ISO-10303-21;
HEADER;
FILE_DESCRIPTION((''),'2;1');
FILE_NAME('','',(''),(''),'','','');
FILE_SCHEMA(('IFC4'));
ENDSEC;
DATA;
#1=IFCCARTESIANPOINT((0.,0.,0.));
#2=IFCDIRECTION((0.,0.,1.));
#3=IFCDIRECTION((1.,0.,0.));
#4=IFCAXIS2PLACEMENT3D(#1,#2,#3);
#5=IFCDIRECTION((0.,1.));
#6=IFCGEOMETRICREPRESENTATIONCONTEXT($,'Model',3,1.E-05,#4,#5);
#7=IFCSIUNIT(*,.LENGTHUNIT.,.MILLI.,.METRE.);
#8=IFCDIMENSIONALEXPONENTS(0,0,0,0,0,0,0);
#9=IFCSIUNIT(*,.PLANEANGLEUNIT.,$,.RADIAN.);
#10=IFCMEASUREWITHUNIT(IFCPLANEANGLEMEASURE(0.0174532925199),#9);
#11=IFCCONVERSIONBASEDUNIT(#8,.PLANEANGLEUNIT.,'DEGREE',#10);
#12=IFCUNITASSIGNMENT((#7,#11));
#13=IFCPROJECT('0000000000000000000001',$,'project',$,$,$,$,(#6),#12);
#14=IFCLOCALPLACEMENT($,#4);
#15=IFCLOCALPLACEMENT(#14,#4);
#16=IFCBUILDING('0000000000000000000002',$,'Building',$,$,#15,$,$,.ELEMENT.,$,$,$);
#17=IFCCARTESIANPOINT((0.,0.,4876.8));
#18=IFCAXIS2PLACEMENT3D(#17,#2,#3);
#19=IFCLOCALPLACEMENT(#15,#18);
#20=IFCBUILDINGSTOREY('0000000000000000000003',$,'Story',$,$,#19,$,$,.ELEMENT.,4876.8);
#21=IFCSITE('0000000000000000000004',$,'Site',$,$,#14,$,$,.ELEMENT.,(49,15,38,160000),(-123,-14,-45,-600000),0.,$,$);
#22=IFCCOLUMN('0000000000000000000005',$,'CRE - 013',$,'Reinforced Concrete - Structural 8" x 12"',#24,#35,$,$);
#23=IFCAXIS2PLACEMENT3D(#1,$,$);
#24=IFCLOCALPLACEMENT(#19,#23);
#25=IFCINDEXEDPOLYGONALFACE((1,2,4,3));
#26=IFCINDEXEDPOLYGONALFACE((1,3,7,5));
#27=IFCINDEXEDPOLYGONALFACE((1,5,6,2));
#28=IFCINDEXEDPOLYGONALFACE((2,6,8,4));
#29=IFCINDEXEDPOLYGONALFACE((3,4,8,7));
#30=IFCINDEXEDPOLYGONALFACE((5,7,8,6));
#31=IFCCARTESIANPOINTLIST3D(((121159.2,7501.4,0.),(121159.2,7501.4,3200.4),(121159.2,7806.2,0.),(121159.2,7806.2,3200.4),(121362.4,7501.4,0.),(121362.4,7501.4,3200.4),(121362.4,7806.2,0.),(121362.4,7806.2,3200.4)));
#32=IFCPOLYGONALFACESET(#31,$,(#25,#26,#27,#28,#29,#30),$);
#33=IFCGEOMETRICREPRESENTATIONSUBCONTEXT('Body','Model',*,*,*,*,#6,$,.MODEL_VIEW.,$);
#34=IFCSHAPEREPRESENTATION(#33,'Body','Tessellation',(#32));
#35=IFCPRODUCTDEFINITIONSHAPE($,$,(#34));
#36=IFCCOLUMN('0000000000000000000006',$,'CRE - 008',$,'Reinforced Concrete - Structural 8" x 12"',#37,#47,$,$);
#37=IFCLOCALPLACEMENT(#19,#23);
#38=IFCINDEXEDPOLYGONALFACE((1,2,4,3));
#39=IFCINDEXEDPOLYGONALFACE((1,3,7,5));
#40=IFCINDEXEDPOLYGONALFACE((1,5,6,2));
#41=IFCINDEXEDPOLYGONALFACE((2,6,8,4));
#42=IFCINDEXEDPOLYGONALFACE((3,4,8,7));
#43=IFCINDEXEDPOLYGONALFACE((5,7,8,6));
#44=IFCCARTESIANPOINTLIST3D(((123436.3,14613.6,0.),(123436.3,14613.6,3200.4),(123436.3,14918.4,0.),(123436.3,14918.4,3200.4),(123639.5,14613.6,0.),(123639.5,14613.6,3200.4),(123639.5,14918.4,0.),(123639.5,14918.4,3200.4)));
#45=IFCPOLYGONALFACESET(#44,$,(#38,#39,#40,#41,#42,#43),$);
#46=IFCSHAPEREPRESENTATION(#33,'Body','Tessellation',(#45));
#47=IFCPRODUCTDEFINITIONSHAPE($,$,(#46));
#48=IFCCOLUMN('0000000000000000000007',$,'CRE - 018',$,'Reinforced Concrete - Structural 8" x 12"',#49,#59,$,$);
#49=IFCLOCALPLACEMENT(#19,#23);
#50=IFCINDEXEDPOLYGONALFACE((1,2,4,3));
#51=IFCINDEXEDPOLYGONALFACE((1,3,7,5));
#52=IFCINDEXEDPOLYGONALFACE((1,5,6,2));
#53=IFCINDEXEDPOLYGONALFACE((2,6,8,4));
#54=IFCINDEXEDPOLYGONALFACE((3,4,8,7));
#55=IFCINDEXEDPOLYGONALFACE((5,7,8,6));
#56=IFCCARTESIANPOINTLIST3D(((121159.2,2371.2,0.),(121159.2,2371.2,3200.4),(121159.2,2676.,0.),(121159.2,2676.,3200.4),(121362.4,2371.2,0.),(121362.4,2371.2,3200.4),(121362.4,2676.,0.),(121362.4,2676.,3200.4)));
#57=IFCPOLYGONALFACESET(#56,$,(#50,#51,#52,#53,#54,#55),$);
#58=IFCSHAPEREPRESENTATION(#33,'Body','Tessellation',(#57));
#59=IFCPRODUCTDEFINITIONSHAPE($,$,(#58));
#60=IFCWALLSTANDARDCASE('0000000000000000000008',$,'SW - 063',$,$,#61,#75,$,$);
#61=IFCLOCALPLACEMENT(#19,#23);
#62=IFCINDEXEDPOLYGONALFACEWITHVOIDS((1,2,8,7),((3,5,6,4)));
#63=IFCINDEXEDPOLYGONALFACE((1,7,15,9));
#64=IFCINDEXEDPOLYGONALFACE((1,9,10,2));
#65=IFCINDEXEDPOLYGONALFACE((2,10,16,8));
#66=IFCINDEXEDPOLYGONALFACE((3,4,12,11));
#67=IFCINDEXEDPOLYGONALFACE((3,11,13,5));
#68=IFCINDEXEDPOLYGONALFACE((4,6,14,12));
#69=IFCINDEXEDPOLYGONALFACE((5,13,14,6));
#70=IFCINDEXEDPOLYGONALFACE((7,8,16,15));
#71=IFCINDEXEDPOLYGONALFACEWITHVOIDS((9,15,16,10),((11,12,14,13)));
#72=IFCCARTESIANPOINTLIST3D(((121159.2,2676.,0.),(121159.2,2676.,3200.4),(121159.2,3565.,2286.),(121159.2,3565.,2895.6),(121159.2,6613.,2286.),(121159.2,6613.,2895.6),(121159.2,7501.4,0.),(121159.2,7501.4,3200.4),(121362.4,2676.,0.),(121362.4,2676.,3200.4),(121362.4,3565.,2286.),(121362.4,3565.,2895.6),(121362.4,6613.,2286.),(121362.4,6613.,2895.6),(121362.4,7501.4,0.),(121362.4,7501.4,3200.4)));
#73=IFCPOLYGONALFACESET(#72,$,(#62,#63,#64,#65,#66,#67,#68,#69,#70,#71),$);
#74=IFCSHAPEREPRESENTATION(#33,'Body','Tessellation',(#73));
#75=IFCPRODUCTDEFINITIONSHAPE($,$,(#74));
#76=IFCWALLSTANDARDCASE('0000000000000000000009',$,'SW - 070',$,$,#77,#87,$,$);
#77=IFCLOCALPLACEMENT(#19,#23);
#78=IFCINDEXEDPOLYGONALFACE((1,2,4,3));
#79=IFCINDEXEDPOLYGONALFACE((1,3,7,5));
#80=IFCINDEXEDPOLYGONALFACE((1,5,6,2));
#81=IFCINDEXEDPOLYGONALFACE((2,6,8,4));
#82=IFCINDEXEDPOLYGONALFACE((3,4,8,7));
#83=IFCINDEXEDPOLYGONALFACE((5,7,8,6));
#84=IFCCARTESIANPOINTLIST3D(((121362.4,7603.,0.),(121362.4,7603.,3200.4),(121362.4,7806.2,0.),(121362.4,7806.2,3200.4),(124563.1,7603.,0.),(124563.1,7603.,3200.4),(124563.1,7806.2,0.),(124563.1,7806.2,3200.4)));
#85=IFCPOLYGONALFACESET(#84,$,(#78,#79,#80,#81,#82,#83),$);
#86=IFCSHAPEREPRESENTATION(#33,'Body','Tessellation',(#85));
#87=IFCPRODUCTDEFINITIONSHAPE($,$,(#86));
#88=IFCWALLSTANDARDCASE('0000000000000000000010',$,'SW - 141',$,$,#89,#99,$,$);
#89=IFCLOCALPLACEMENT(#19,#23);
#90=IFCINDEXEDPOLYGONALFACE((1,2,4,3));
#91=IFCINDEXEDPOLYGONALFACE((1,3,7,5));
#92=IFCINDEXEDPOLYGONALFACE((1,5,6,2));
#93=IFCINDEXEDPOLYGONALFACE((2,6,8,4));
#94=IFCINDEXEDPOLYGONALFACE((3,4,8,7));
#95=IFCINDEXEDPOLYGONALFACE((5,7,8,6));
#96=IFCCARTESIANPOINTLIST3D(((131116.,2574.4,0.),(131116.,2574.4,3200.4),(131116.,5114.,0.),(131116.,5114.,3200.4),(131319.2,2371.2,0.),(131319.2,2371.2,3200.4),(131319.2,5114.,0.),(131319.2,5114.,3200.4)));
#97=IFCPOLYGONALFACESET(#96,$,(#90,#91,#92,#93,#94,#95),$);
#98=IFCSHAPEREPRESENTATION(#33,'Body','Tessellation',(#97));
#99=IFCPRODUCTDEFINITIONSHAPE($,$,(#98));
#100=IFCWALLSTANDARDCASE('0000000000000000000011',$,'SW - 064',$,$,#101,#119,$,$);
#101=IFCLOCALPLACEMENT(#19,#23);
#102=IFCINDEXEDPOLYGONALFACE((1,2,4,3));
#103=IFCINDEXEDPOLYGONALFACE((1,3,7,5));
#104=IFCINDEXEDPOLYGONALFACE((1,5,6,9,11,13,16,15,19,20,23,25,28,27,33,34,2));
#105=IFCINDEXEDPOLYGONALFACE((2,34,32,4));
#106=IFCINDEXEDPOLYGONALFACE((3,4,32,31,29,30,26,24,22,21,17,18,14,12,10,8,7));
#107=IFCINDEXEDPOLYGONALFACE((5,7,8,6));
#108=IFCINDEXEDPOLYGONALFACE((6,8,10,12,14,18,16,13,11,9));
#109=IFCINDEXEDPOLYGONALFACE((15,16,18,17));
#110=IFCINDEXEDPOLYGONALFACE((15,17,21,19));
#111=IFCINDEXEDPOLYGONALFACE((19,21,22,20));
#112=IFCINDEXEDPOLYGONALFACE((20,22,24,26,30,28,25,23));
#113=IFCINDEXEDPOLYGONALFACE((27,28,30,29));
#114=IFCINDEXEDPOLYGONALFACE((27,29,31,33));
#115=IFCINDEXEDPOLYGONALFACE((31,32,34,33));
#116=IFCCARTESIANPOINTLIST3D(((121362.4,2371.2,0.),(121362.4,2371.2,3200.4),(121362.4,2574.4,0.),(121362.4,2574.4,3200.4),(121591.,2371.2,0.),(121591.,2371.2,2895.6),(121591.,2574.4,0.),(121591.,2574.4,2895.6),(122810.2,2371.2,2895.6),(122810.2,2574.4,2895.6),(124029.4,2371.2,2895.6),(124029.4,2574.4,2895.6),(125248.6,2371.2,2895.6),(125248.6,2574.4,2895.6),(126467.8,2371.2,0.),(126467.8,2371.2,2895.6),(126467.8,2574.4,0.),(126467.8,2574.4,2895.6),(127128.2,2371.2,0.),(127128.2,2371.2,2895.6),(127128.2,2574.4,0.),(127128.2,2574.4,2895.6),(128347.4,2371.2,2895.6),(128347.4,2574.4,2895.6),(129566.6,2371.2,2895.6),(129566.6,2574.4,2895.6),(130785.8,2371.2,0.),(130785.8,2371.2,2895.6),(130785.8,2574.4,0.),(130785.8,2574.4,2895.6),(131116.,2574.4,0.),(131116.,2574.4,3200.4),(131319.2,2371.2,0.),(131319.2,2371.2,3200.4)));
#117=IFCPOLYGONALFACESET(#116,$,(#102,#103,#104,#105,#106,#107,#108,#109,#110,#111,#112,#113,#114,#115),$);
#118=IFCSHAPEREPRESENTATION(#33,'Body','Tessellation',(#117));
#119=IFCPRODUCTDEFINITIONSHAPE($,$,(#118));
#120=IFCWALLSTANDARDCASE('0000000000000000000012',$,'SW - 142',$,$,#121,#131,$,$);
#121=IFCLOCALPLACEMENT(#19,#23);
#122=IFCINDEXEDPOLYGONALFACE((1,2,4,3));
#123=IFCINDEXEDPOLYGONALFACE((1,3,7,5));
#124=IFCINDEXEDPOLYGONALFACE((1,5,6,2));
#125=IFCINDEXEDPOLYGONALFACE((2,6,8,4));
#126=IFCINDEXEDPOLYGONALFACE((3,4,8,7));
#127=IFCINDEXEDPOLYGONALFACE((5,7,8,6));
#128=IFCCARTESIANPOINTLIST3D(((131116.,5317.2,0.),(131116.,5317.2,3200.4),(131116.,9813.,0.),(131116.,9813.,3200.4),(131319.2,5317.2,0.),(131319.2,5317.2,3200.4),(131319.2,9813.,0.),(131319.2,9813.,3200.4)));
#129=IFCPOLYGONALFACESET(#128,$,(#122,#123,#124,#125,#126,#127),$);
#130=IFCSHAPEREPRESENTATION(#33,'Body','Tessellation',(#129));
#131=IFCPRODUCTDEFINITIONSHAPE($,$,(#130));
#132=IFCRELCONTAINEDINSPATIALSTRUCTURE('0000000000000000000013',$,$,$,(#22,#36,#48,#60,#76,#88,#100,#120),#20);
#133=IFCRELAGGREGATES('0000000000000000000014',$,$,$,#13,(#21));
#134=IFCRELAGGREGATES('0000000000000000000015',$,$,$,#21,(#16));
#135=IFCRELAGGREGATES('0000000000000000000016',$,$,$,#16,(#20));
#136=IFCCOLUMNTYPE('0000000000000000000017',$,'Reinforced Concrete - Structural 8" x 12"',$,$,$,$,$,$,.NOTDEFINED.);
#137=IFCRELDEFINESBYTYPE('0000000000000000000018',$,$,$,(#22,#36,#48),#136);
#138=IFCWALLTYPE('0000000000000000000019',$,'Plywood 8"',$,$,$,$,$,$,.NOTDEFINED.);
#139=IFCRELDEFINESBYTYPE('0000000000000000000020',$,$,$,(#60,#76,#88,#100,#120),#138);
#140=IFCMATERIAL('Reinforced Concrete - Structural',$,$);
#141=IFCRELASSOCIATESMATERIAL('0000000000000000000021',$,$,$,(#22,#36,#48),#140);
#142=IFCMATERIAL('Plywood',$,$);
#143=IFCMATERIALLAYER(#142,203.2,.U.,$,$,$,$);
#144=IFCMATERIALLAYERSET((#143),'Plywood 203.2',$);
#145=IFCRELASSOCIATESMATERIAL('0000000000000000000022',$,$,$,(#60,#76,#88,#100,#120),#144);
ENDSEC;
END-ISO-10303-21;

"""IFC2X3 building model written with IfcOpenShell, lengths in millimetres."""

from ifc_helpers import new_model, entity, si_unit, converted_unit, direction, frame, origin_with_axes, origin_2d_with_axis, place, context, subcontext, project, spatial, polyline, rectangle, outline, extrude, material, layer, layer_set, layer_usage, type_object, element, save


model = new_model("IFC2X3")

# Units and contexts
model_context = context("Model", 3, precision=1e-05, world=origin_with_axes(), true_north=direction((0.0, 1.0)))
body_context = subcontext(model_context, "Body", "Model", "MODEL_VIEW")
ifc_project = project(units=[si_unit("LENGTHUNIT", "METRE", prefix="MILLI"), converted_unit("PLANEANGLEUNIT", "DEGREE", entity("IfcPlaneAngleMeasure", 0.0174532925199), si_unit("PLANEANGLEUNIT", "RADIAN"), dimensions=[0, 0, 0, 0, 0, 0, 0])], contexts=[model_context])

# Site, building, storey
site_placement = place(None, origin_with_axes())
site = spatial("IfcSite", under=ifc_project, at=site_placement, Name="Site", CompositionType="ELEMENT", RefLatitude=(49, 15, 38, 160000), RefLongitude=(-123, -14, -45, -600000), RefElevation=0.0)
building_placement = place(site_placement, origin_with_axes())
building = spatial("IfcBuilding", under=site, at=building_placement, Name="Building", CompositionType="ELEMENT")
storey_placement = place(building_placement, frame((0.0, 0.0, 4876.8), z_axis=(0.0, 0.0, 1.0), x_axis=(1.0, 0.0, 0.0)))
storey = spatial("IfcBuildingStorey", under=building, at=storey_placement, Name="Story", CompositionType="ELEMENT", Elevation=4876.8)

# Columns
ifc_material_1 = material(Name="Reinforced Concrete - Structural")
column_type = type_object("IfcColumnType", Name="Reinforced Concrete - Structural 8\" x 12\"", PredefinedType="NOTDEFINED")
for number, where, z_axis, x_axis, name in (
    (1, (121260.8, 7653.8, 0.0), (0.0, 0.0, 1.0), (1.0, 0.0, 0.0), "CRE - 013"),
    (2, (123537.9, 14766.0, 0.0), (0.0, 0.0, 1.0), (1.0, 0.0, 0.0), "CRE - 008"),
    (3, (121260.8, 2523.6, 0.0), (0.0, 0.0, 1.0), (1.0, 0.0, 0.0), "CRE - 018"),
):
    element("IfcColumn", number, at=place(storey_placement, frame(where, z_axis=z_axis, x_axis=x_axis)), inside=storey, type_object=column_type, material=ifc_material_1, Name=name, ObjectType="Reinforced Concrete - Structural 8\" x 12\"", context=body_context, shape_type="SweptSolid", body=[
        extrude(rectangle(XDim=203.2, YDim=304.8, at=origin_2d_with_axis()), origin_with_axes(), (0.0, 0.0, 1.0), 3200.4),
    ])

# Wall, opening
ifc_material_2 = material(Name="Plywood")
ifc_layer_1 = layer(ifc_material_2, 203.2, ventilated="UNKNOWN")
ifc_layer_set_1 = layer_set([ifc_layer_1], Name="Plywood 203.2")
ifc_layer_usage_1 = layer_usage(ifc_layer_set_1, "AXIS2", "NEGATIVE", 0.0)
wall_type_1 = type_object("IfcWallType", Name="Plywood 8\"", PredefinedType="NOTDEFINED")
wall_1_placement = place(storey_placement, frame((121362.4, 7501.4, 0.0), z_axis=(0.0, 0.0, 1.0), x_axis=(0.0, -1.0, 0.0)))
wall_1 = element("IfcWallStandardCase", 4, at=wall_1_placement, inside=storey, type_object=wall_type_1, material=ifc_layer_usage_1, Name="SW - 063", context=body_context, shape_type="SweptSolid", body=[
    extrude(outline(polyline([(0.0, -203.2), (4825.5, -203.2), (4825.5, 0.0), (0.0, 0.0), (0.0, -203.2)])), origin_with_axes(), (0.0, 0.0, 1.0), 3200.4),
])
opening_1_placement = place(wall_1_placement, frame((2412.5, 0.0, 2286.0), z_axis=(0.0, 0.0, 1.0), x_axis=(1.0, 0.0, 0.0)))
element("IfcOpeningElement", 5, at=opening_1_placement, cuts=wall_1, context=body_context, shape_type="SweptSolid", body=[
    extrude(rectangle(XDim=3048.0, YDim=609.6, at=origin_2d_with_axis()), frame((0.0, 203.2, 304.8), z_axis=(0.0, -1.0, 0.0), x_axis=(-1.0, 0.0, 0.0)), (0.0, 0.0, 1.0), 609.6),
])

# Walls
ifc_layer_usage_2 = layer_usage(ifc_layer_set_1, "AXIS2", "NEGATIVE", 0.0)
wall_2_placement = place(storey_placement, frame((124563.1, 7603.0, 0.0), z_axis=(0.0, 0.0, 1.0), x_axis=(-1.0, 0.0, 0.0)))
element("IfcWallStandardCase", 6, at=wall_2_placement, inside=storey, type_object=wall_type_1, material=ifc_layer_usage_2, Name="SW - 070", context=body_context, shape_type="SweptSolid", body=[
    extrude(outline(polyline([(0.0, -203.2), (3200.6, -203.2), (3200.6, 0.0), (0.0, 0.0), (0.0, -203.2)])), origin_with_axes(), (0.0, 0.0, 1.0), 3200.4),
])
ifc_layer_usage_3 = layer_usage(ifc_layer_set_1, "AXIS2", "POSITIVE", -203.2)
wall_3_placement = place(storey_placement, frame((131116.0, 2574.4, 0.0), z_axis=(0.0, 0.0, 1.0), x_axis=(0.0, 1.0, 0.0)))
element("IfcWallStandardCase", 7, at=wall_3_placement, inside=storey, type_object=wall_type_1, material=ifc_layer_usage_3, Name="SW - 141", context=body_context, shape_type="SweptSolid", body=[
    extrude(outline(polyline([(-203.2, -203.2), (2539.7, -203.2), (2539.7, 0.0), (0.0, 0.0), (-203.2, -203.2)])), origin_with_axes(), (0.0, 0.0, 1.0), 3200.4),
])

# Wall, openings
ifc_layer_usage_4 = layer_usage(ifc_layer_set_1, "AXIS2", "NEGATIVE", 0.0)
wall_4_placement = place(storey_placement, frame((121362.4, 2574.4, 0.0), z_axis=(0.0, 0.0, 1.0), x_axis=(1.0, 0.0, 0.0)))
wall_4 = element("IfcWallStandardCase", 8, at=wall_4_placement, inside=storey, type_object=wall_type_1, material=ifc_layer_usage_4, Name="SW - 064", context=body_context, shape_type="SweptSolid", body=[
    extrude(outline(polyline([(0.0, -203.2), (9956.8, -203.2), (9753.6, 0.0), (0.0, 0.0), (0.0, -203.2)])), origin_with_axes(), (0.0, 0.0, 1.0), 3200.4),
])
opening_2_placement = place(wall_4_placement, frame((8813.8, 0.0, 0.0), z_axis=(0.0, 0.0, 1.0), x_axis=(1.0, 0.0, 0.0)))
element("IfcOpeningElement", 9, at=opening_2_placement, cuts=wall_4, context=body_context, shape_type="SweptSolid", body=[
    extrude(rectangle(XDim=1219.2, YDim=2895.6, at=origin_2d_with_axis()), frame((0.0, 203.2, 1447.8), z_axis=(0.0, -1.0, 0.0), x_axis=(-1.0, 0.0, 0.0)), (0.0, 0.0, 1.0), 609.6),
])
opening_3_placement = place(wall_4_placement, frame((7594.6, 0.0, 0.0), z_axis=(0.0, 0.0, 1.0), x_axis=(1.0, 0.0, 0.0)))
element("IfcOpeningElement", 10, at=opening_3_placement, cuts=wall_4, context=body_context, shape_type="SweptSolid", body=[
    extrude(rectangle(XDim=1219.2, YDim=2895.6, at=origin_2d_with_axis()), frame((0.0, 203.2, 1447.8), z_axis=(0.0, -1.0, 0.0), x_axis=(-1.0, 0.0, 0.0)), (0.0, 0.0, 1.0), 609.6),
])
opening_4_placement = place(wall_4_placement, frame((6375.4, 0.0, 0.0), z_axis=(0.0, 0.0, 1.0), x_axis=(1.0, 0.0, 0.0)))
element("IfcOpeningElement", 11, at=opening_4_placement, cuts=wall_4, context=body_context, shape_type="SweptSolid", body=[
    extrude(rectangle(XDim=1219.2, YDim=2895.6, at=origin_2d_with_axis()), frame((0.0, 203.2, 1447.8), z_axis=(0.0, 1.0, 0.0), x_axis=(1.0, 0.0, 0.0)), (0.0, 0.0, -1.0), 609.6),
])
opening_5_placement = place(wall_4_placement, frame((4495.8, 0.0, 0.0), z_axis=(0.0, 0.0, 1.0), x_axis=(1.0, 0.0, 0.0)))
element("IfcOpeningElement", 12, at=opening_5_placement, cuts=wall_4, context=body_context, shape_type="SweptSolid", body=[
    extrude(rectangle(XDim=1219.2, YDim=2895.6, at=origin_2d_with_axis()), frame((0.0, 203.2, 1447.8), z_axis=(0.0, -1.0, 0.0), x_axis=(-1.0, 0.0, 0.0)), (0.0, 0.0, 1.0), 609.6),
])
opening_6_placement = place(wall_4_placement, frame((3276.6, 0.0, 0.0), z_axis=(0.0, 0.0, 1.0), x_axis=(1.0, 0.0, 0.0)))
element("IfcOpeningElement", 13, at=opening_6_placement, cuts=wall_4, context=body_context, shape_type="SweptSolid", body=[
    extrude(rectangle(XDim=1219.2, YDim=2895.6, at=origin_2d_with_axis()), frame((0.0, 203.2, 1447.8), z_axis=(0.0, -1.0, 0.0), x_axis=(-1.0, 0.0, 0.0)), (0.0, 0.0, 1.0), 609.6),
])
opening_7_placement = place(wall_4_placement, frame((2057.4, 0.0, 0.0), z_axis=(0.0, 0.0, 1.0), x_axis=(1.0, 0.0, 0.0)))
element("IfcOpeningElement", 14, at=opening_7_placement, cuts=wall_4, context=body_context, shape_type="SweptSolid", body=[
    extrude(rectangle(XDim=1219.2, YDim=2895.6, at=origin_2d_with_axis()), frame((0.0, 203.2, 1447.8), z_axis=(0.0, -1.0, 0.0), x_axis=(-1.0, 0.0, 0.0)), (0.0, 0.0, 1.0), 609.6),
])
opening_8_placement = place(wall_4_placement, frame((838.2, 0.0, 0.0), z_axis=(0.0, 0.0, 1.0), x_axis=(1.0, 0.0, 0.0)))
element("IfcOpeningElement", 15, at=opening_8_placement, cuts=wall_4, context=body_context, shape_type="SweptSolid", body=[
    extrude(rectangle(XDim=1219.2, YDim=2895.6, at=origin_2d_with_axis()), frame((0.0, 203.2, 1447.8), z_axis=(0.0, 1.0, 0.0), x_axis=(1.0, 0.0, 0.0)), (0.0, 0.0, -1.0), 609.6),
])

# Wall
ifc_layer_usage_5 = layer_usage(ifc_layer_set_1, "AXIS2", "POSITIVE", -203.2)
wall_5_placement = place(storey_placement, frame((131116.0, 5317.2, 0.0), z_axis=(0.0, 0.0, 1.0), x_axis=(0.0, 1.0, 0.0)))
element("IfcWallStandardCase", 16, at=wall_5_placement, inside=storey, type_object=wall_type_1, material=ifc_layer_usage_5, Name="SW - 142", context=body_context, shape_type="SweptSolid", body=[
    extrude(outline(polyline([(0.0, -203.2), (4495.8, -203.2), (4495.8, 0.0), (0.0, 0.0), (0.0, -203.2)])), origin_with_axes(), (0.0, 0.0, 1.0), 3200.4),
])

save(model, "model.ifc")
